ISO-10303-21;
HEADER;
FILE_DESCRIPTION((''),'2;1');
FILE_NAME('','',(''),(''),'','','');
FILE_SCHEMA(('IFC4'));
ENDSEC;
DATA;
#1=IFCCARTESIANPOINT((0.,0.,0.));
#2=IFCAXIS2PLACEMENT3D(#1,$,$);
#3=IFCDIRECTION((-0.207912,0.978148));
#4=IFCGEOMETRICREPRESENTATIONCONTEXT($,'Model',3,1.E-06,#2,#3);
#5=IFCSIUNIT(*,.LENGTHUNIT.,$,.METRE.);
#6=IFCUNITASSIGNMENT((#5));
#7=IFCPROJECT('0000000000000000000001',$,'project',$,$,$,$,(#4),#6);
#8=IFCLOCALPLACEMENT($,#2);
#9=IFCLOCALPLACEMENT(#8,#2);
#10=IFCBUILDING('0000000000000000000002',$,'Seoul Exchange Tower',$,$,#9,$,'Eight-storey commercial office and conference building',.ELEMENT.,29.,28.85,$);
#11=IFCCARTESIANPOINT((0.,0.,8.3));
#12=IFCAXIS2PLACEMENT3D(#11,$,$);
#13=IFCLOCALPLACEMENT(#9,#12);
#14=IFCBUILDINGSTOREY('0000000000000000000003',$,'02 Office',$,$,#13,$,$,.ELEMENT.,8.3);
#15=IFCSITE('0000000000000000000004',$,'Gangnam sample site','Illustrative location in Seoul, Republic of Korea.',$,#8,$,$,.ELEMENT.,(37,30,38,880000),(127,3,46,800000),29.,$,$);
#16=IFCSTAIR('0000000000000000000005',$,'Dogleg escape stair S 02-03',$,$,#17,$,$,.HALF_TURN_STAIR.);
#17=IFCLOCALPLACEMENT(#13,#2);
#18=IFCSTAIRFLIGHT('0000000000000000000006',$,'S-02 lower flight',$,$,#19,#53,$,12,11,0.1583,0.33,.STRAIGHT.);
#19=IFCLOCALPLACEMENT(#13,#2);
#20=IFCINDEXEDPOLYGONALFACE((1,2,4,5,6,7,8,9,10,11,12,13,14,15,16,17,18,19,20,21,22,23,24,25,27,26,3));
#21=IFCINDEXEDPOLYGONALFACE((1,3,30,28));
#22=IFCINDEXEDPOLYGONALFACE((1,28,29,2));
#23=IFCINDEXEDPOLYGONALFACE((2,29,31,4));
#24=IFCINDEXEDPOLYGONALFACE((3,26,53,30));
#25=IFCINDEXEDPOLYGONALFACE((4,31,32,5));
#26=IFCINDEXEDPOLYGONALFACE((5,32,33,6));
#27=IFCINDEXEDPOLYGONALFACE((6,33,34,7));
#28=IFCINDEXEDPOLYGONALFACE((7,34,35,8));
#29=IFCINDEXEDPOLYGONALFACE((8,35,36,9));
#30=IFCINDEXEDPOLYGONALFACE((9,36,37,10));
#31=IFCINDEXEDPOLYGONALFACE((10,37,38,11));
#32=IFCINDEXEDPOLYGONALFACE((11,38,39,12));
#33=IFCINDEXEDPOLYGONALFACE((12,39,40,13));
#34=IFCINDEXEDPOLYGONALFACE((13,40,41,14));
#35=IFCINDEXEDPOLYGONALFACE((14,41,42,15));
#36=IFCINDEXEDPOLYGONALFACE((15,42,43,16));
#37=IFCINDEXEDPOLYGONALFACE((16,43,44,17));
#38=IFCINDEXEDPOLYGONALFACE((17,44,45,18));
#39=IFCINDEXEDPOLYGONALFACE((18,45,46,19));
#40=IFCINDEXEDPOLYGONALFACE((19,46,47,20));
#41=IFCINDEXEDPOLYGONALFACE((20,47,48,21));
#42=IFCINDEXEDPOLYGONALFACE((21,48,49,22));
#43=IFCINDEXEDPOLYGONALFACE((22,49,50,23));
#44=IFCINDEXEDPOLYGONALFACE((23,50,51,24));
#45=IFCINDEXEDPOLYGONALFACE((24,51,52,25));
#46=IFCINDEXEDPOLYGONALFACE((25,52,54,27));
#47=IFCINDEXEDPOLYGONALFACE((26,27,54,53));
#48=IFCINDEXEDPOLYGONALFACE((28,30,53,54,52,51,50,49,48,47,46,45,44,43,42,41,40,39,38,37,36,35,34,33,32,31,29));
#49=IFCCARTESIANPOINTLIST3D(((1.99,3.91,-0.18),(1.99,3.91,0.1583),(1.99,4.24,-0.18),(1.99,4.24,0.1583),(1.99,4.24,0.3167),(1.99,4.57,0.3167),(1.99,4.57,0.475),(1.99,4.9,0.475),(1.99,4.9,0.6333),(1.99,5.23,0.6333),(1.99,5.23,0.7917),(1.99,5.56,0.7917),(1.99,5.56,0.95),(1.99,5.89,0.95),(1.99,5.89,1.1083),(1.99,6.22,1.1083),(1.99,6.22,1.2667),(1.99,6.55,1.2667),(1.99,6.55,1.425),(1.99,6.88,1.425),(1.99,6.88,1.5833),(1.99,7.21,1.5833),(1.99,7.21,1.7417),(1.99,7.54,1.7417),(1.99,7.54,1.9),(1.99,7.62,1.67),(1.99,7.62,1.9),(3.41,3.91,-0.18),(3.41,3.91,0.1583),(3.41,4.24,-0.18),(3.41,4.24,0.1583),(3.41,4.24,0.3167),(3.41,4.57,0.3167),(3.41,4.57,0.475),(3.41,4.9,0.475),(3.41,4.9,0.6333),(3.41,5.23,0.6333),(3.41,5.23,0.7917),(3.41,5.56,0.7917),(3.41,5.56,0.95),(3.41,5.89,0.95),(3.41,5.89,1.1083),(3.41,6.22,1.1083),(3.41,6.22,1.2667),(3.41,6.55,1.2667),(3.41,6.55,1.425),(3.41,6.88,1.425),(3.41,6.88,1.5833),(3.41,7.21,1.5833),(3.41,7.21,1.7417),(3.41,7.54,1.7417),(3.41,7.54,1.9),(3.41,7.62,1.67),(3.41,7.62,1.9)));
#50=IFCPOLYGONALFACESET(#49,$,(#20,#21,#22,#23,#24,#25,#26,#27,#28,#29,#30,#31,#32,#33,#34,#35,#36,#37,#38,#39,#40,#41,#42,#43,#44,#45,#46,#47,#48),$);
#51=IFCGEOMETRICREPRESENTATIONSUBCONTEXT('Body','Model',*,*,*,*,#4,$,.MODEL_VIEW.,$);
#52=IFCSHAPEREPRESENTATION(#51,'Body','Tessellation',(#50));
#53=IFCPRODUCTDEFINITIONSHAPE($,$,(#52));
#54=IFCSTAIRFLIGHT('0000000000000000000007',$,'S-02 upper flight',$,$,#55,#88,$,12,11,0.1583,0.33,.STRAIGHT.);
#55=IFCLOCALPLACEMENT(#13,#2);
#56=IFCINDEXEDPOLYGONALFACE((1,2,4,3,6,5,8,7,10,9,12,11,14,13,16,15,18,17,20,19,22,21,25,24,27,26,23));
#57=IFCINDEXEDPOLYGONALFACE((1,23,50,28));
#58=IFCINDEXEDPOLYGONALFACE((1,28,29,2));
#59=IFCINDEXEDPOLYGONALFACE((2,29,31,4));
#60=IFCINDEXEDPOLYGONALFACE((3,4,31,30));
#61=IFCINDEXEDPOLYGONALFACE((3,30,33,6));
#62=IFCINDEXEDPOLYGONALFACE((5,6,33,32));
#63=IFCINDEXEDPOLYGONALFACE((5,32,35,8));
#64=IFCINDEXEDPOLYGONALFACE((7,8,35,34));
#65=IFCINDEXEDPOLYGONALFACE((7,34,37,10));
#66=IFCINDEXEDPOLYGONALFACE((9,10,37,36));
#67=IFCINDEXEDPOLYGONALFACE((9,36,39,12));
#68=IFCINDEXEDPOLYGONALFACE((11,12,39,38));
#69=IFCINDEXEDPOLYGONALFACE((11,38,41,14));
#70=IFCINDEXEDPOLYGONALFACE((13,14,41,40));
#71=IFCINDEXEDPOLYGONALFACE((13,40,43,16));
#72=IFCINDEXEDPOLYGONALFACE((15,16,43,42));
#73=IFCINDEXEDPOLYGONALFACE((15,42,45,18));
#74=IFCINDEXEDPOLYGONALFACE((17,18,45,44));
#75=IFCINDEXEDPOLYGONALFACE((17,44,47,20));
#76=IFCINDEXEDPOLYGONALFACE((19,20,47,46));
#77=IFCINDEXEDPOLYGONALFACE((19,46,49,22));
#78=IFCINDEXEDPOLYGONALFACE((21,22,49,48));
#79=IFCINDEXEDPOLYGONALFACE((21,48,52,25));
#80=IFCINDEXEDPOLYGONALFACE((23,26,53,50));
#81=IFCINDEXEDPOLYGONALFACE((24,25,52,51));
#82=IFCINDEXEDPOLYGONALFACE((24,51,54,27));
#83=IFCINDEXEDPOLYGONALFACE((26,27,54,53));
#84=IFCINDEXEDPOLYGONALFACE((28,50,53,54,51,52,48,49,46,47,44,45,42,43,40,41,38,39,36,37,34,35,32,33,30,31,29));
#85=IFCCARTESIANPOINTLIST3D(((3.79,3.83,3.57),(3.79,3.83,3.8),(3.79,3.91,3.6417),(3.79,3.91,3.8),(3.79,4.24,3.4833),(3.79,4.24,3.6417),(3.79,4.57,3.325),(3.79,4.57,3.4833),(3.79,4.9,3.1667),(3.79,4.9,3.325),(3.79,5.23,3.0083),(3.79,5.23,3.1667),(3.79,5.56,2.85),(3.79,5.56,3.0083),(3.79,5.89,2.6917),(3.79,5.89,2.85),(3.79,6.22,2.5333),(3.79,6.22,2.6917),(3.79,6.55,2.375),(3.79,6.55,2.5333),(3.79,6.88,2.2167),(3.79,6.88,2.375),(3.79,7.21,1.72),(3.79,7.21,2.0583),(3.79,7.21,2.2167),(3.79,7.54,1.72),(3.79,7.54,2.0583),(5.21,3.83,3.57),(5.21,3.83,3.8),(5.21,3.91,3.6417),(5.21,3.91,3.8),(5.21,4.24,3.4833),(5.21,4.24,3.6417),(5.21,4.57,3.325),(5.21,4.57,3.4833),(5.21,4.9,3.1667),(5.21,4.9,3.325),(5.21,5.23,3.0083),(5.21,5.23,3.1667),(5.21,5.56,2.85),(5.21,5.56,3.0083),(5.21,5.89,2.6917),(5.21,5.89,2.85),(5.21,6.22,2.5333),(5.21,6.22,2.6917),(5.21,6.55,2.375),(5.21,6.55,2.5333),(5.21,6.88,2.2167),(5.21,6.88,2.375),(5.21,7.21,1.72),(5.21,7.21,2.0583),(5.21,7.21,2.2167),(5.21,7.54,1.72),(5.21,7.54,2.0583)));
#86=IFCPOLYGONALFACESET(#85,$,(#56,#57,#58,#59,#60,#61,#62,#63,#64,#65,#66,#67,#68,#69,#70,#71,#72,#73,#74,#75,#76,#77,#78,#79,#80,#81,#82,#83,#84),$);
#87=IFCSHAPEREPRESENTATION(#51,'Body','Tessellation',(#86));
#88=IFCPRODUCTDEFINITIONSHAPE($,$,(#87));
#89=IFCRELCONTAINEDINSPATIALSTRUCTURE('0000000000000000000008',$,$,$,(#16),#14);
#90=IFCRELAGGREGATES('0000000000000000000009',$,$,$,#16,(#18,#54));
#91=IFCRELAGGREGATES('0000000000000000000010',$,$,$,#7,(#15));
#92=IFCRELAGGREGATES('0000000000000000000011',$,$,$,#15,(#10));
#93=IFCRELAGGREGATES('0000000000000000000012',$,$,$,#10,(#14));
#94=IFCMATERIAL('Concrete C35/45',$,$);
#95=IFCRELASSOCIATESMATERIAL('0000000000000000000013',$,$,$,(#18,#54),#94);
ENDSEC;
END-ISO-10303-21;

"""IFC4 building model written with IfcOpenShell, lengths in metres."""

from ifc_helpers import new_model, si_unit, direction, frame, origin, place, context, subcontext, project, spatial, polyline, outline, extrude, material, element, aggregate, save


model = new_model("IFC4")

# Units and contexts
model_context = context("Model", 3, precision=1e-06, world=origin(), true_north=direction((-0.207912, 0.978148)))
body_context = subcontext(model_context, "Body", "Model", "MODEL_VIEW")
ifc_project = project(units=[si_unit("LENGTHUNIT", "METRE")], contexts=[model_context])

# Site, building, storey
site_placement = place(None, origin())
site = spatial("IfcSite", under=ifc_project, at=site_placement, Name="Gangnam sample site", Description="Illustrative location in Seoul, Republic of Korea.", CompositionType="ELEMENT", RefLatitude=(37, 30, 38, 880000), RefLongitude=(127, 3, 46, 800000), RefElevation=29.0)
building_placement = place(site_placement, origin())
building = spatial("IfcBuilding", under=site, at=building_placement, Name="Seoul Exchange Tower", LongName="Eight-storey commercial office and conference building", CompositionType="ELEMENT", ElevationOfRefHeight=29.0, ElevationOfTerrain=28.85)
storey_placement = place(building_placement, frame((0.0, 0.0, 8.3)))
storey = spatial("IfcBuildingStorey", under=building, at=storey_placement, Name="02 Office", CompositionType="ELEMENT", Elevation=8.3)

# Shared definitions
ifc_material_1 = material(Name="Concrete C35/45")
placement_1 = place(storey_placement, origin())

# Stair
placement_2 = place(placement_1, origin())
stair_1 = element("IfcStair", 1, at=placement_1, inside=storey, Name="Dogleg escape stair S 02-03", PredefinedType="HALF_TURN_STAIR")

# Stair flights
stair_flight_1 = element("IfcStairFlight", 2, at=placement_2, material=ifc_material_1, Name="S-02 lower flight", NumberOfRisers=12, NumberOfTreads=11, PredefinedType="STRAIGHT", RiserHeight=0.1583, TreadLength=0.33, context=body_context, shape_type="SweptSolid", body=[
    extrude(outline(polyline([(0.0, -0.18), (0.0, 0.1583), (0.33, 0.1583), (0.33, 0.3167), (0.66, 0.3167), (0.66, 0.475), (0.99, 0.475), (0.99, 0.6333), (1.32, 0.6333), (1.32, 0.7917), (1.65, 0.7917), (1.65, 0.95), (1.98, 0.95), (1.98, 1.1083), (2.31, 1.1083), (2.31, 1.2667), (2.64, 1.2667), (2.64, 1.425), (2.97, 1.425), (2.97, 1.5833), (3.3, 1.5833), (3.3, 1.7417), (3.63, 1.7417), (3.63, 1.9), (3.71, 1.9), (3.71, 1.67), (0.33, -0.18), (0.0, -0.18)])), frame((1.99, 3.91, 0.0), z_axis=(1.0, 0.0, 0.0), x_axis=(0.0, 1.0, 0.0)), (0.0, 0.0, 1.0), 1.42),
])
stair_flight_2 = element("IfcStairFlight", 3, at=placement_2, material=ifc_material_1, Name="S-02 upper flight", NumberOfRisers=12, NumberOfTreads=11, PredefinedType="STRAIGHT", RiserHeight=0.1583, TreadLength=0.33, context=body_context, shape_type="SweptSolid", body=[
    extrude(outline(polyline([(0.0, -0.18), (0.0, 0.1583), (0.33, 0.1583), (0.33, 0.3167), (0.66, 0.3167), (0.66, 0.475), (0.99, 0.475), (0.99, 0.6333), (1.32, 0.6333), (1.32, 0.7917), (1.65, 0.7917), (1.65, 0.95), (1.98, 0.95), (1.98, 1.1083), (2.31, 1.1083), (2.31, 1.2667), (2.64, 1.2667), (2.64, 1.425), (2.97, 1.425), (2.97, 1.5833), (3.3, 1.5833), (3.3, 1.7417), (3.63, 1.7417), (3.63, 1.9), (3.71, 1.9), (3.71, 1.67), (0.33, -0.18), (0.0, -0.18)])), frame((5.21, 7.54, 1.9), z_axis=(-1.0, 0.0, 0.0), x_axis=(0.0, -1.0, 0.0)), (0.0, 0.0, 1.0), 1.42),
])

aggregate(stair_1, [stair_flight_1, stair_flight_2])

save(model, "model.ifc")
